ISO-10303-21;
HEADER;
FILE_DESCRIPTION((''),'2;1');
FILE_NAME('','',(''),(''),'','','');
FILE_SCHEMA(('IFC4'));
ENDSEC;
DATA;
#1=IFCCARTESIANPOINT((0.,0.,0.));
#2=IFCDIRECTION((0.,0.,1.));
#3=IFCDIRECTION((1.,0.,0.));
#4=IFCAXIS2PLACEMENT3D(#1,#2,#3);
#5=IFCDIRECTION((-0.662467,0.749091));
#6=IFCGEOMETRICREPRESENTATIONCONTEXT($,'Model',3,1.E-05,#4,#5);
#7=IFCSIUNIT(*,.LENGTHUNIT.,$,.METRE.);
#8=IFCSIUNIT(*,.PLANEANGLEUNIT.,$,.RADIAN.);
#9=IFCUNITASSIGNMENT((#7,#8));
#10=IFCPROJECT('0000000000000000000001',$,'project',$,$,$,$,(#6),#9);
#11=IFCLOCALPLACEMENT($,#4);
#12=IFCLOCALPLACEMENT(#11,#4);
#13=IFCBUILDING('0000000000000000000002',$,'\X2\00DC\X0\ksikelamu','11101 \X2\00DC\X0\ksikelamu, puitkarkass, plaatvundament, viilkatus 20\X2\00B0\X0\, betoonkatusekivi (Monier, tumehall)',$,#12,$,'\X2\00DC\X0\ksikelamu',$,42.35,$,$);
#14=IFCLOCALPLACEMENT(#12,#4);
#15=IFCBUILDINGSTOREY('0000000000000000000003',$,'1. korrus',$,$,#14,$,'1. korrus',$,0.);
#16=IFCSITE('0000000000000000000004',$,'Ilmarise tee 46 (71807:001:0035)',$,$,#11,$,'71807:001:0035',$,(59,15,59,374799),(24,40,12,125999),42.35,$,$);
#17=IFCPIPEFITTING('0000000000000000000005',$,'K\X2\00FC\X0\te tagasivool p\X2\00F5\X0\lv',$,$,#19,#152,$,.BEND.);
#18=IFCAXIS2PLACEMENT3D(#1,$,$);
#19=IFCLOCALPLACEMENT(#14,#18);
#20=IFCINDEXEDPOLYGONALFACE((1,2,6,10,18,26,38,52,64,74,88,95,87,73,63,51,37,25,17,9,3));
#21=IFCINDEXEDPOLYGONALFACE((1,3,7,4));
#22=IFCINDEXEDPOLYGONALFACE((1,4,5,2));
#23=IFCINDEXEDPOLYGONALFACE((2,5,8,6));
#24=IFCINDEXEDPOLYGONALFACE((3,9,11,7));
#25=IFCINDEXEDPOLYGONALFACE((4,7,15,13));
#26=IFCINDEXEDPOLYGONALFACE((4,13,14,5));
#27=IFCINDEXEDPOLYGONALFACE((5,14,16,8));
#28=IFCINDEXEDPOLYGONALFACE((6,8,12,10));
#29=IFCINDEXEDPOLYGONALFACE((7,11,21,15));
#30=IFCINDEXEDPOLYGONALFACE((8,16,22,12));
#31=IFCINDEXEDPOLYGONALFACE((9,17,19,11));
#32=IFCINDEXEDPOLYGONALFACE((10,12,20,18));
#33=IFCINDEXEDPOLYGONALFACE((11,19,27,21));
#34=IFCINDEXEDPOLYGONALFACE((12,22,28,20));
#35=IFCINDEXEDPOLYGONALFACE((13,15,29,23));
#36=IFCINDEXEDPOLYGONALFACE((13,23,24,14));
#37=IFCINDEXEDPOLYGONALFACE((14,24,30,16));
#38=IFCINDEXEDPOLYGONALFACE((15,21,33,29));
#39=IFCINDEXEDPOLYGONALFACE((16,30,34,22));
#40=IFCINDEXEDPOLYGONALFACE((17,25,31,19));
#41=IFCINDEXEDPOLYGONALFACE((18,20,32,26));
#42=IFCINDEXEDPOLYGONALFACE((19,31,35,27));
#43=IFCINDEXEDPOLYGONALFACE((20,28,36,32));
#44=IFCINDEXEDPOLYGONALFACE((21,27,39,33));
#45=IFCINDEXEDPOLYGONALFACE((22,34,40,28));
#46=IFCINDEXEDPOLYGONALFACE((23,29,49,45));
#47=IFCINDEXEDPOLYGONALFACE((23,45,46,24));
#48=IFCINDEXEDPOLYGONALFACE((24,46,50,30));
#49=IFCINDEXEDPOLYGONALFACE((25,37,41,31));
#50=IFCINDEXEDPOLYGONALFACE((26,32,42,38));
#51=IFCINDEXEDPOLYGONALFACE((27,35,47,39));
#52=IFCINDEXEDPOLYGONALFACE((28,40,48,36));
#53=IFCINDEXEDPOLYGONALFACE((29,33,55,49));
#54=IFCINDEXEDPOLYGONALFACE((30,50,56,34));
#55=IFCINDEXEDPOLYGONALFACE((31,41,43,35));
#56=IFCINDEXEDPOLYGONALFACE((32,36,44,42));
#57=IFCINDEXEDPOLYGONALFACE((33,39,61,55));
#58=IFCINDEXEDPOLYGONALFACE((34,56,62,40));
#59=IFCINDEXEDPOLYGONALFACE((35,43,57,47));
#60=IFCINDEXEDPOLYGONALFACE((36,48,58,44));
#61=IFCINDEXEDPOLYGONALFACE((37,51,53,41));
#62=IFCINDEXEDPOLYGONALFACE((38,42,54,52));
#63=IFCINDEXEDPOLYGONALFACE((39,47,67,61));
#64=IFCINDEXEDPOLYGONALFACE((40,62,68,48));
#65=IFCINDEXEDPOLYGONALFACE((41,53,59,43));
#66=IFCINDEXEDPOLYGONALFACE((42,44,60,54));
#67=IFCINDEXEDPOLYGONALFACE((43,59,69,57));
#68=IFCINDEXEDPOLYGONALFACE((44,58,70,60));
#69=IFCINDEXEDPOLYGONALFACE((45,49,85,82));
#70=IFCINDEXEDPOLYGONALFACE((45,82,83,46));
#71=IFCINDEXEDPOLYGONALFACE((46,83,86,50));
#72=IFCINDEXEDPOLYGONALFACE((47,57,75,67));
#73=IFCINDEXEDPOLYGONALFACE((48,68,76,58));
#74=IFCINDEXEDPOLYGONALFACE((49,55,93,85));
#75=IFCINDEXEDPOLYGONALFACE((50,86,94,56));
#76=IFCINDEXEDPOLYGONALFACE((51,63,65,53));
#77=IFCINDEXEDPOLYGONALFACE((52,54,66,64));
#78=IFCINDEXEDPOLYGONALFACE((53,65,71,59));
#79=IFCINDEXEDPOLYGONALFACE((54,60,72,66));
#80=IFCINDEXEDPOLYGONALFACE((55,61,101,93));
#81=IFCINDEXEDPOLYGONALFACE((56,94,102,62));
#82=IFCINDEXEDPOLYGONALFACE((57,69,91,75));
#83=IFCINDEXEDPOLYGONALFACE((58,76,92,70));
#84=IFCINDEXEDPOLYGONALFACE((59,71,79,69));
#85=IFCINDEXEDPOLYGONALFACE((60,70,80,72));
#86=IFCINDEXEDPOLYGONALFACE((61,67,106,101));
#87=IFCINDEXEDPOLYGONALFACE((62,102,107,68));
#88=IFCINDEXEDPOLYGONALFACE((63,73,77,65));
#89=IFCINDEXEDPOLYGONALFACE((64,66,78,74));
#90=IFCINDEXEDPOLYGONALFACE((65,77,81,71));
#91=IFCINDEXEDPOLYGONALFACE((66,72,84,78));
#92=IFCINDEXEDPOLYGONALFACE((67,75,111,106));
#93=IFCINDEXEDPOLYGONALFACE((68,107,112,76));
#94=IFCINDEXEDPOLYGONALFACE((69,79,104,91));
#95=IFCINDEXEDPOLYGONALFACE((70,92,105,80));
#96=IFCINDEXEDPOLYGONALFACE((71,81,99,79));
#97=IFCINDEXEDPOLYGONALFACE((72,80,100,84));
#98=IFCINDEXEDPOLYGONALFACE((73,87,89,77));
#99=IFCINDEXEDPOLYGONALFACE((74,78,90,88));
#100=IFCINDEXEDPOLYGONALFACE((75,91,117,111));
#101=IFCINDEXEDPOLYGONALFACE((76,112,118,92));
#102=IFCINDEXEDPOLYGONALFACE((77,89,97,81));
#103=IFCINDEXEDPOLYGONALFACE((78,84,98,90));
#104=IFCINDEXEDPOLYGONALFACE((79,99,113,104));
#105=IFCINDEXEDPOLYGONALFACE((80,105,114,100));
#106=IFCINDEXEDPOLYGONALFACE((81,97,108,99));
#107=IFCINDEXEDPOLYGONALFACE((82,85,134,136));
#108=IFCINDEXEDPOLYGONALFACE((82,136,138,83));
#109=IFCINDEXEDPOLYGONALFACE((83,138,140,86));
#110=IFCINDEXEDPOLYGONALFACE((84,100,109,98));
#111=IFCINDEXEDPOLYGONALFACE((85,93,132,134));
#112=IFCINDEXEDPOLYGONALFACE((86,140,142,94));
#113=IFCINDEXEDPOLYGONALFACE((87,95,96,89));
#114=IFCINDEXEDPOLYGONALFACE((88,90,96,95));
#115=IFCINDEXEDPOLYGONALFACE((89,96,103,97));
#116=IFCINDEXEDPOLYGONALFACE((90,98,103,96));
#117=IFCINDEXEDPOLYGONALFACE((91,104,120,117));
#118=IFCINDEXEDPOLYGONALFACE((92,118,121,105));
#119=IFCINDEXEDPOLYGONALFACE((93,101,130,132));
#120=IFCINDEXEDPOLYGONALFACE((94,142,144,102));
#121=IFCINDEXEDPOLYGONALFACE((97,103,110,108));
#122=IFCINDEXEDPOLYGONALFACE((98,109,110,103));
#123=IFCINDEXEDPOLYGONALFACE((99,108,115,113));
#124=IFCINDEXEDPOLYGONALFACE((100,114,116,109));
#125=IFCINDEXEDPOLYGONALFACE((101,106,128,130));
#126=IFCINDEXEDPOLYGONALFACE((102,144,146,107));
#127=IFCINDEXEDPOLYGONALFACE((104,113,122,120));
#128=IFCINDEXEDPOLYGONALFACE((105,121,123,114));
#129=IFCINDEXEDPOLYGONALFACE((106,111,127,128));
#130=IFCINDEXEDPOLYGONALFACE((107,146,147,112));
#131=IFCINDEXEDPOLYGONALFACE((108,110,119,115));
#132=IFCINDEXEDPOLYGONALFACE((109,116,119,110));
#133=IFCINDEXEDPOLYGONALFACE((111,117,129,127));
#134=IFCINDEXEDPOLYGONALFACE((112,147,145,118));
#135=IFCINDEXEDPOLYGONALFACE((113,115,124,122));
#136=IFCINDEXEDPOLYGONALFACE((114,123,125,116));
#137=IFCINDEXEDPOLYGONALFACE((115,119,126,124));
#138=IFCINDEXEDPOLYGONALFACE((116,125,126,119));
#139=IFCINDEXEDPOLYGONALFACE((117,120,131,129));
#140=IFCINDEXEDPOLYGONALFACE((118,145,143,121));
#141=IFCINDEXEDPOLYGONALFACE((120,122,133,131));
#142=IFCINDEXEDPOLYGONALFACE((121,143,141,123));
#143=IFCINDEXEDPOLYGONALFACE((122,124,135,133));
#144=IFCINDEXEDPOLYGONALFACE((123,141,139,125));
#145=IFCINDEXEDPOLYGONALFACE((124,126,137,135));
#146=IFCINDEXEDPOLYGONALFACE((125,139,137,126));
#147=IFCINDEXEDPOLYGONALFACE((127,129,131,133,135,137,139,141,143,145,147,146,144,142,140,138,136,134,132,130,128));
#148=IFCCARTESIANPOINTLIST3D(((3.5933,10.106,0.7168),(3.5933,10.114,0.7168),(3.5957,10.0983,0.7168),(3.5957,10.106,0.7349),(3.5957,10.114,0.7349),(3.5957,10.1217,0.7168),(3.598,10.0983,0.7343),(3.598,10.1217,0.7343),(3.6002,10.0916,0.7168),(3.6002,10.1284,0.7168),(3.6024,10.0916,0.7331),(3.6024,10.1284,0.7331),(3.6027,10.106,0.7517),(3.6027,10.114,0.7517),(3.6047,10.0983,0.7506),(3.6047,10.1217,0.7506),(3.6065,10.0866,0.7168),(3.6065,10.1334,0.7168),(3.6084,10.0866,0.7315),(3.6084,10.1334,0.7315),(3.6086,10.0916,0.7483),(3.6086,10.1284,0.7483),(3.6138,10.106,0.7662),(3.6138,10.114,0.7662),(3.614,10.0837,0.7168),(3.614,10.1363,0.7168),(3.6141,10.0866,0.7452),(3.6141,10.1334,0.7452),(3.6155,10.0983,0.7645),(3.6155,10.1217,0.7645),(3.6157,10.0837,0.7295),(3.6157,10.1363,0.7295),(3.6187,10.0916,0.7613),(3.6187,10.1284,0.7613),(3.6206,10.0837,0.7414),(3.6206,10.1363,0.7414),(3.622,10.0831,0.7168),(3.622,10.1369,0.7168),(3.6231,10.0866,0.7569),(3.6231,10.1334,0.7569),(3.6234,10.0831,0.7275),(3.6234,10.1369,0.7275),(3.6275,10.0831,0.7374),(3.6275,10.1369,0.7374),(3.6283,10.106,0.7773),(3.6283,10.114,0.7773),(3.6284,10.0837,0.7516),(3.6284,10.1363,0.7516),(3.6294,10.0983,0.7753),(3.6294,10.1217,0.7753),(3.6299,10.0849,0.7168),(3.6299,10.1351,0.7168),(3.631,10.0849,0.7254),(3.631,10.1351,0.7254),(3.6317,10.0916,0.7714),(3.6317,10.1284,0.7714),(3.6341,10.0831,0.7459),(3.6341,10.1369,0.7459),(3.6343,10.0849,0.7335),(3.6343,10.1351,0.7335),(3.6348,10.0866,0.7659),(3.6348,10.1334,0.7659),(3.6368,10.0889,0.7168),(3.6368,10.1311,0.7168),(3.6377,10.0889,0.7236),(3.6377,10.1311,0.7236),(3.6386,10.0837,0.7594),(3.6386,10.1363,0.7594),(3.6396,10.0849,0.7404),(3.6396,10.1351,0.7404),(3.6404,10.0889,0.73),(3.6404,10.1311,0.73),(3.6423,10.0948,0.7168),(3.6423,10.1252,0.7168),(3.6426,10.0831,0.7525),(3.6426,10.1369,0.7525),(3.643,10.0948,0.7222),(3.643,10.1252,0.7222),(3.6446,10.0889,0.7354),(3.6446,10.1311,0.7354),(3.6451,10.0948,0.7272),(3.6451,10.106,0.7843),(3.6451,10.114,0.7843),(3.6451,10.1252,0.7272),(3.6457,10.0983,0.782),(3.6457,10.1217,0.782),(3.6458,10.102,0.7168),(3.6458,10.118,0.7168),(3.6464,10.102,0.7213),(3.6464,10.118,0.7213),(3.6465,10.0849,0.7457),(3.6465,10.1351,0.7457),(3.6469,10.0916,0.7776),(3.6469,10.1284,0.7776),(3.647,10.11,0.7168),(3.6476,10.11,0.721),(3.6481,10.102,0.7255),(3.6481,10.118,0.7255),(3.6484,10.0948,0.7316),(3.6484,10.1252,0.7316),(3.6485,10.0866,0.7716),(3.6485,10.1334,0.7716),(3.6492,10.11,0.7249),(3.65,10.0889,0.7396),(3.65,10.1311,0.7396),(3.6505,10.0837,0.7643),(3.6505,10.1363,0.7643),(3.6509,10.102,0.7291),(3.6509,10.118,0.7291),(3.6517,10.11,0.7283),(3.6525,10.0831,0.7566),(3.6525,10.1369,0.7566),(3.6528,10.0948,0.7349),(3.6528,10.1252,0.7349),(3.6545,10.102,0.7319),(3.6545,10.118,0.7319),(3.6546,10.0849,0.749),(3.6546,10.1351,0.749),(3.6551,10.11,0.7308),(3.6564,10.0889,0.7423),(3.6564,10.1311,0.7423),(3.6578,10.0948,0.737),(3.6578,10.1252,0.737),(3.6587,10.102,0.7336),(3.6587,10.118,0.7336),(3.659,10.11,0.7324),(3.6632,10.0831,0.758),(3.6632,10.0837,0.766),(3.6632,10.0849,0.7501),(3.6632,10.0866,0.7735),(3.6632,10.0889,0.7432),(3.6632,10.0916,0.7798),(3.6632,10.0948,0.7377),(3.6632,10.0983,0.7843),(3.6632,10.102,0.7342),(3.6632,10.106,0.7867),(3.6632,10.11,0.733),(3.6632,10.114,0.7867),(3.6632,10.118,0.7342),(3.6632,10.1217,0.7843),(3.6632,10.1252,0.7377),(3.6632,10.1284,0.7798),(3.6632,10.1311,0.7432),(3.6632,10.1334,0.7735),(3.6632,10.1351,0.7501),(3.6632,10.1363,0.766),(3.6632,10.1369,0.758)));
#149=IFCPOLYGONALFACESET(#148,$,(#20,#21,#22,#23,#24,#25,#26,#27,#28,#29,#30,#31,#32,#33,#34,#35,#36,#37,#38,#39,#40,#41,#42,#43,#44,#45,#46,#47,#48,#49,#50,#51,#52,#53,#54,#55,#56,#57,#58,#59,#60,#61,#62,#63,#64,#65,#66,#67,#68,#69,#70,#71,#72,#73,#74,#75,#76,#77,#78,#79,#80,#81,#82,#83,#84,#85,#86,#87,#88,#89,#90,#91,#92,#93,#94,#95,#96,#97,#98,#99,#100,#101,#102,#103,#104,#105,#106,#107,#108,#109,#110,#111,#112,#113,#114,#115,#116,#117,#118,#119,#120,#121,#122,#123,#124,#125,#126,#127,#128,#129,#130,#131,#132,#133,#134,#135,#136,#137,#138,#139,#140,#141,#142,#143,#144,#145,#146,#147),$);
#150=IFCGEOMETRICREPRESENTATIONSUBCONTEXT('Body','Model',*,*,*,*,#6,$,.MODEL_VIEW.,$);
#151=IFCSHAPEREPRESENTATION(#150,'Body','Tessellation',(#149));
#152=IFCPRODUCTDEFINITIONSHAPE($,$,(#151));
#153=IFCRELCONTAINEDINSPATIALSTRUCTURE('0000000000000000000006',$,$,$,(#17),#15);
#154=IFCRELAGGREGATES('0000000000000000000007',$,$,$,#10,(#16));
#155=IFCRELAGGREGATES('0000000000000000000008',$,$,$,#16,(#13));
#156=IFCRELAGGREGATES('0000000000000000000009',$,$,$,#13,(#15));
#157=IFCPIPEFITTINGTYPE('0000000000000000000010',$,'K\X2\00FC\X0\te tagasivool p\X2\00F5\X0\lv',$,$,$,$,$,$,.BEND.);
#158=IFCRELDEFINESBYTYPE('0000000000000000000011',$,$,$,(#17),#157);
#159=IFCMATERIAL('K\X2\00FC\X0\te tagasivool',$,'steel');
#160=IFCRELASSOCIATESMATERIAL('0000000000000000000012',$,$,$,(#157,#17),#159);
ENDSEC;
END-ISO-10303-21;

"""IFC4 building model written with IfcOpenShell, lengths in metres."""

from ifc_helpers import new_model, entity, si_unit, direction, frame, origin_with_axes, place, context, subcontext, project, spatial, material, type_object, element, save


model = new_model("IFC4")

# Units and contexts
model_context = context("Model", 3, precision=1e-05, world=origin_with_axes(), true_north=direction((-0.662467, 0.749091)))
body_context = subcontext(model_context, "Body", "Model", "MODEL_VIEW")
ifc_project = project(units=[si_unit("LENGTHUNIT", "METRE"), si_unit("PLANEANGLEUNIT", "RADIAN")], contexts=[model_context])

# Site, building, storey
site_placement = place(None, origin_with_axes())
site = spatial("IfcSite", under=ifc_project, at=site_placement, Name="Ilmarise tee 46 (71807:001:0035)", LongName="71807:001:0035", RefLatitude=(59, 15, 59, 374799), RefLongitude=(24, 40, 12, 125999), RefElevation=42.35)
building_placement = place(site_placement, origin_with_axes())
building = spatial("IfcBuilding", under=site, at=building_placement, Name="Üksikelamu", Description="11101 Üksikelamu, puitkarkass, plaatvundament, viilkatus 20°, betoonkatusekivi (Monier, tumehall)", LongName="Üksikelamu", ElevationOfRefHeight=42.35)
storey_placement = place(building_placement, origin_with_axes())
storey = spatial("IfcBuildingStorey", under=building, at=storey_placement, Name="1. korrus", LongName="1. korrus", Elevation=0.0)

# Pipe fitting
ifc_material_1 = material(Name="Küte tagasivool", Category="steel")
pipe_fitting_type_1 = type_object("IfcPipeFittingType", Name="Küte tagasivool põlv", PredefinedType="BEND", material=ifc_material_1)
pipe_fitting_1_placement = place(storey_placement, frame((3.62, 10.11, 0.76), z_axis=(0.0, 0.0, 1.0), x_axis=(1.0, 0.0, 0.0)))
element("IfcPipeFitting", 1, at=pipe_fitting_1_placement, inside=storey, type_object=pipe_fitting_type_1, material=ifc_material_1, Name="Küte tagasivool põlv", PredefinedType="BEND", context=body_context, shape_type="SweptSolid", body=[
    entity("IfcRevolvedAreaSolid", entity("IfcCircleProfileDef", "AREA", None, None, 0.027), entity("IfcAxis2Placement3D", entity("IfcCartesianPoint", [0.0, 0.0, -0.0432]), entity("IfcDirection", [0.0, 0.0, 1.0]), entity("IfcDirection", [1.0, 0.0, 0.0])), entity("IfcAxis1Placement", entity("IfcCartesianPoint", [0.0432, 0.0, 0.0]), entity("IfcDirection", [0.0, 1.0, 0.0])), 1.570796),
])

save(model, "model.ifc")
